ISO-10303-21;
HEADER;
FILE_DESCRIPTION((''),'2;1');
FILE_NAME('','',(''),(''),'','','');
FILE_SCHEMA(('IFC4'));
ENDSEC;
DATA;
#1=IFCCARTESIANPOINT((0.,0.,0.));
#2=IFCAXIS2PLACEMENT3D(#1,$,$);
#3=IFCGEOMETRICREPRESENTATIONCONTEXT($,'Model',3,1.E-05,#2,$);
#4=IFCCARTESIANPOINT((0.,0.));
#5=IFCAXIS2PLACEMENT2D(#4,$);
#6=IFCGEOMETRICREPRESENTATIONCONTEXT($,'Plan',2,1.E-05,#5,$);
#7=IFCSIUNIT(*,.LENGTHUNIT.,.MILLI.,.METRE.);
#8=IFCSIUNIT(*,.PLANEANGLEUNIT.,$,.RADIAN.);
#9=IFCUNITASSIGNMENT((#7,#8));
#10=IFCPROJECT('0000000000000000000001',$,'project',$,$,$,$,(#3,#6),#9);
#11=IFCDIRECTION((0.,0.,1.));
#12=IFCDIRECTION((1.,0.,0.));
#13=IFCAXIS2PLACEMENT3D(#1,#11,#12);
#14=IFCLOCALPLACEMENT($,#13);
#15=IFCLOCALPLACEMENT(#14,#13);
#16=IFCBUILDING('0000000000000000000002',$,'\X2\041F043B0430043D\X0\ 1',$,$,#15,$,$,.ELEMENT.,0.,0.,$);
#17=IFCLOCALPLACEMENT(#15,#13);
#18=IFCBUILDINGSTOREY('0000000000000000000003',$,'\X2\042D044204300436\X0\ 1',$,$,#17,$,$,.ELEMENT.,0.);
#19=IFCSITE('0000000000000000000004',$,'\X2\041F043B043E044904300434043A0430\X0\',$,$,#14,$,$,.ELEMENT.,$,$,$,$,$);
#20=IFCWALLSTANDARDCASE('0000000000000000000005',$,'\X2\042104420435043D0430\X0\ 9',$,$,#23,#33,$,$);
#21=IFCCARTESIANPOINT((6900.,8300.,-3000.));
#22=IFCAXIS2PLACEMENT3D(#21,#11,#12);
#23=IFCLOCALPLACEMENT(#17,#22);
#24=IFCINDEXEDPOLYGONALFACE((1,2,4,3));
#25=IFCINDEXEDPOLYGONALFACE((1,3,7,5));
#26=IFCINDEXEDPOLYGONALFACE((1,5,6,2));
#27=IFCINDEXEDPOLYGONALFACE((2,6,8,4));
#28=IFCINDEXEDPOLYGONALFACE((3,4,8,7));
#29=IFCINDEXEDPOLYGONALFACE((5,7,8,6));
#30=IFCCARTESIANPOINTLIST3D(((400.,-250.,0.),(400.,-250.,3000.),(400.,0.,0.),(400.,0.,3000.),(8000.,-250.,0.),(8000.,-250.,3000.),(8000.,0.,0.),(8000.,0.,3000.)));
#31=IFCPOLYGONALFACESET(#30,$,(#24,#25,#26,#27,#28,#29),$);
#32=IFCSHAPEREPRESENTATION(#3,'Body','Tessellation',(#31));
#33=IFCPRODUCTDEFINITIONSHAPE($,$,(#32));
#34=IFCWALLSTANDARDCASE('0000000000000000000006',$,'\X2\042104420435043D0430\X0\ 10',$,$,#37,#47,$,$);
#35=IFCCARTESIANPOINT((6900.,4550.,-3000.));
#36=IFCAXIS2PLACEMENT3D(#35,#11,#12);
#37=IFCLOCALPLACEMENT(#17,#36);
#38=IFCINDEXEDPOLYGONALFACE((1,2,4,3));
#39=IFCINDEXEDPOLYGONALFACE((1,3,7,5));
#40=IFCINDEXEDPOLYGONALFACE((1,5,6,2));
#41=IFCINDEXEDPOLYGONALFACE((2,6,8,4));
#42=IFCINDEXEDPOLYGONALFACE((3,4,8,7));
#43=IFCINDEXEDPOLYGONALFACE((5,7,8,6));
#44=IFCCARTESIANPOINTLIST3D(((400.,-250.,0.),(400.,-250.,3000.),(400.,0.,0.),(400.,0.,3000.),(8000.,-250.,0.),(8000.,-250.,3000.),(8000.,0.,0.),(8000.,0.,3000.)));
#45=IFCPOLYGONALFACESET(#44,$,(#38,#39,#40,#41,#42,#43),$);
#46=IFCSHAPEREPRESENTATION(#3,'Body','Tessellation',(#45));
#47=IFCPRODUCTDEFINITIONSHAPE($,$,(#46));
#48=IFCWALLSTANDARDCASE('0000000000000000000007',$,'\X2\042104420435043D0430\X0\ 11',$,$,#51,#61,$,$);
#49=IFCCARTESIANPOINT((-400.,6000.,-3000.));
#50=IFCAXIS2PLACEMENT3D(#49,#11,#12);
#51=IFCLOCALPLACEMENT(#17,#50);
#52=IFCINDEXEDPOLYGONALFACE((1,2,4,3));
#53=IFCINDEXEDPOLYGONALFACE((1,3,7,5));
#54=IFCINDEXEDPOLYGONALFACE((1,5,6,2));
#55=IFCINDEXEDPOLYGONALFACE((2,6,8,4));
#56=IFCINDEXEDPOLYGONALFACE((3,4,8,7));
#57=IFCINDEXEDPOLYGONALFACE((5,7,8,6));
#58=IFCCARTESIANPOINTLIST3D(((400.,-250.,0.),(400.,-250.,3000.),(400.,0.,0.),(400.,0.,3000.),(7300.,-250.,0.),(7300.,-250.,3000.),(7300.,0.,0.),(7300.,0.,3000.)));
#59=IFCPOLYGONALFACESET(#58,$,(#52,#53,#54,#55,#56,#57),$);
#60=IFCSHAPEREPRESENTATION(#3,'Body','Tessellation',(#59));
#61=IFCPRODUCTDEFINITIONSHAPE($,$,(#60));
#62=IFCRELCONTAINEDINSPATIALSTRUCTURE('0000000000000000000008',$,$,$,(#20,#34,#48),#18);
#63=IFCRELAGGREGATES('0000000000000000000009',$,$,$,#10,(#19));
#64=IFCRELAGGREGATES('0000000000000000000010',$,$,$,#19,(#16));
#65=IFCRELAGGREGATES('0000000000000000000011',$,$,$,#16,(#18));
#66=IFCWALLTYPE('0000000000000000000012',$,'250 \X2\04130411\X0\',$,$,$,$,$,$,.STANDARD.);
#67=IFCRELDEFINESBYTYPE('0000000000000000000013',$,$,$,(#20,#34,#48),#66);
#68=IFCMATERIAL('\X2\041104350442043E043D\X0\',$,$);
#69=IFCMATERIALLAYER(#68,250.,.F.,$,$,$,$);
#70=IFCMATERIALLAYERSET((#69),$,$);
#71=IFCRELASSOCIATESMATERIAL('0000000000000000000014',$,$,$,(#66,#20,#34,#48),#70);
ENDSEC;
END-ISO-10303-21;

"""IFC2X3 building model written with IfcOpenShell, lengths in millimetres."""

from ifc_helpers import new_model, si_unit, frame, origin, origin_with_axes, origin_2d, place, context, project, spatial, polyline, segment, composite_curve, outline, extrude, material, layer, layer_set, layer_usage, type_object, element, save


model = new_model("IFC2X3")

# Units and contexts
model_context = context("Model", 3, precision=1e-05, world=origin())
plan_context = context("Plan", 2, precision=1e-05, world=origin_2d())
ifc_project = project(units=[si_unit("LENGTHUNIT", "METRE", prefix="MILLI"), si_unit("PLANEANGLEUNIT", "RADIAN")], contexts=[model_context, plan_context])

# Site, building, storey
site_placement = place(None, origin_with_axes())
site = spatial("IfcSite", under=ifc_project, at=site_placement, Name="Площадка", CompositionType="ELEMENT")
building_placement = place(site_placement, origin_with_axes())
building = spatial("IfcBuilding", under=site, at=building_placement, Name="План 1", CompositionType="ELEMENT", ElevationOfRefHeight=0.0, ElevationOfTerrain=0.0)
storey_placement = place(building_placement, origin_with_axes())
storey = spatial("IfcBuildingStorey", under=building, at=storey_placement, Name="Этаж 1", CompositionType="ELEMENT", Elevation=0.0)

# Walls
ifc_material = material(Name="Бетон")
ifc_layer_1 = layer(ifc_material, 250.0, ventilated=False)
ifc_layer_set_1 = layer_set([ifc_layer_1])
ifc_layer_usage_1 = layer_usage(ifc_layer_set_1, "AXIS2", "POSITIVE", -250.0)
wall_type_1 = type_object("IfcWallType", Name="250 ГБ", PredefinedType="STANDARD", material=ifc_layer_set_1)
wall_1_placement = place(storey_placement, frame((6900.0, 8300.0, -3000.0), z_axis=(0.0, 0.0, 1.0), x_axis=(1.0, 0.0, 0.0)))
element("IfcWallStandardCase", 1, at=wall_1_placement, inside=storey, type_object=wall_type_1, material=ifc_layer_usage_1, Name="Стена 9", context=model_context, shape_type="SweptSolid", body=[
    extrude(outline(composite_curve([segment(polyline([(400.0, 0.0), (400.0, -250.0)]), True, "CONTINUOUS"), segment(polyline([(400.0, -250.0), (8000.0, -250.0)]), True, "CONTINUOUS"), segment(polyline([(8000.0, -250.0), (8000.0, 0.0)]), True, "CONTINUOUS"), segment(polyline([(8000.0, 0.0), (400.0, 0.0)]), True, "CONTINUOUS")], self_intersect=False)), origin_with_axes(), (0.0, 0.0, 1.0), 3000.0),
])
ifc_layer_usage_2 = layer_usage(ifc_layer_set_1, "AXIS2", "POSITIVE", -250.0)
wall_2_placement = place(storey_placement, frame((6900.0, 4550.0, -3000.0), z_axis=(0.0, 0.0, 1.0), x_axis=(1.0, 0.0, 0.0)))
element("IfcWallStandardCase", 2, at=wall_2_placement, inside=storey, type_object=wall_type_1, material=ifc_layer_usage_2, Name="Стена 10", context=model_context, shape_type="SweptSolid", body=[
    extrude(outline(composite_curve([segment(polyline([(400.0, 0.0), (400.0, -250.0)]), True, "CONTINUOUS"), segment(polyline([(400.0, -250.0), (8000.0, -250.0)]), True, "CONTINUOUS"), segment(polyline([(8000.0, -250.0), (8000.0, 0.0)]), True, "CONTINUOUS"), segment(polyline([(8000.0, 0.0), (400.0, 0.0)]), True, "CONTINUOUS")], self_intersect=False)), origin_with_axes(), (0.0, 0.0, 1.0), 3000.0),
])
ifc_layer_usage_3 = layer_usage(ifc_layer_set_1, "AXIS2", "POSITIVE", -250.0)
wall_3_placement = place(storey_placement, frame((-400.0, 6000.0, -3000.0), z_axis=(0.0, 0.0, 1.0), x_axis=(1.0, 0.0, 0.0)))
element("IfcWallStandardCase", 3, at=wall_3_placement, inside=storey, type_object=wall_type_1, material=ifc_layer_usage_3, Name="Стена 11", context=model_context, shape_type="SweptSolid", body=[
    extrude(outline(composite_curve([segment(polyline([(400.0, 0.0), (400.0, -250.0)]), True, "CONTINUOUS"), segment(polyline([(400.0, -250.0), (7300.0, -250.0)]), True, "CONTINUOUS"), segment(polyline([(7300.0, -250.0), (7300.0, 0.0)]), True, "CONTINUOUS"), segment(polyline([(7300.0, 0.0), (400.0, 0.0)]), True, "CONTINUOUS")], self_intersect=False)), origin_with_axes(), (0.0, 0.0, 1.0), 3000.0),
])

save(model, "model.ifc")
